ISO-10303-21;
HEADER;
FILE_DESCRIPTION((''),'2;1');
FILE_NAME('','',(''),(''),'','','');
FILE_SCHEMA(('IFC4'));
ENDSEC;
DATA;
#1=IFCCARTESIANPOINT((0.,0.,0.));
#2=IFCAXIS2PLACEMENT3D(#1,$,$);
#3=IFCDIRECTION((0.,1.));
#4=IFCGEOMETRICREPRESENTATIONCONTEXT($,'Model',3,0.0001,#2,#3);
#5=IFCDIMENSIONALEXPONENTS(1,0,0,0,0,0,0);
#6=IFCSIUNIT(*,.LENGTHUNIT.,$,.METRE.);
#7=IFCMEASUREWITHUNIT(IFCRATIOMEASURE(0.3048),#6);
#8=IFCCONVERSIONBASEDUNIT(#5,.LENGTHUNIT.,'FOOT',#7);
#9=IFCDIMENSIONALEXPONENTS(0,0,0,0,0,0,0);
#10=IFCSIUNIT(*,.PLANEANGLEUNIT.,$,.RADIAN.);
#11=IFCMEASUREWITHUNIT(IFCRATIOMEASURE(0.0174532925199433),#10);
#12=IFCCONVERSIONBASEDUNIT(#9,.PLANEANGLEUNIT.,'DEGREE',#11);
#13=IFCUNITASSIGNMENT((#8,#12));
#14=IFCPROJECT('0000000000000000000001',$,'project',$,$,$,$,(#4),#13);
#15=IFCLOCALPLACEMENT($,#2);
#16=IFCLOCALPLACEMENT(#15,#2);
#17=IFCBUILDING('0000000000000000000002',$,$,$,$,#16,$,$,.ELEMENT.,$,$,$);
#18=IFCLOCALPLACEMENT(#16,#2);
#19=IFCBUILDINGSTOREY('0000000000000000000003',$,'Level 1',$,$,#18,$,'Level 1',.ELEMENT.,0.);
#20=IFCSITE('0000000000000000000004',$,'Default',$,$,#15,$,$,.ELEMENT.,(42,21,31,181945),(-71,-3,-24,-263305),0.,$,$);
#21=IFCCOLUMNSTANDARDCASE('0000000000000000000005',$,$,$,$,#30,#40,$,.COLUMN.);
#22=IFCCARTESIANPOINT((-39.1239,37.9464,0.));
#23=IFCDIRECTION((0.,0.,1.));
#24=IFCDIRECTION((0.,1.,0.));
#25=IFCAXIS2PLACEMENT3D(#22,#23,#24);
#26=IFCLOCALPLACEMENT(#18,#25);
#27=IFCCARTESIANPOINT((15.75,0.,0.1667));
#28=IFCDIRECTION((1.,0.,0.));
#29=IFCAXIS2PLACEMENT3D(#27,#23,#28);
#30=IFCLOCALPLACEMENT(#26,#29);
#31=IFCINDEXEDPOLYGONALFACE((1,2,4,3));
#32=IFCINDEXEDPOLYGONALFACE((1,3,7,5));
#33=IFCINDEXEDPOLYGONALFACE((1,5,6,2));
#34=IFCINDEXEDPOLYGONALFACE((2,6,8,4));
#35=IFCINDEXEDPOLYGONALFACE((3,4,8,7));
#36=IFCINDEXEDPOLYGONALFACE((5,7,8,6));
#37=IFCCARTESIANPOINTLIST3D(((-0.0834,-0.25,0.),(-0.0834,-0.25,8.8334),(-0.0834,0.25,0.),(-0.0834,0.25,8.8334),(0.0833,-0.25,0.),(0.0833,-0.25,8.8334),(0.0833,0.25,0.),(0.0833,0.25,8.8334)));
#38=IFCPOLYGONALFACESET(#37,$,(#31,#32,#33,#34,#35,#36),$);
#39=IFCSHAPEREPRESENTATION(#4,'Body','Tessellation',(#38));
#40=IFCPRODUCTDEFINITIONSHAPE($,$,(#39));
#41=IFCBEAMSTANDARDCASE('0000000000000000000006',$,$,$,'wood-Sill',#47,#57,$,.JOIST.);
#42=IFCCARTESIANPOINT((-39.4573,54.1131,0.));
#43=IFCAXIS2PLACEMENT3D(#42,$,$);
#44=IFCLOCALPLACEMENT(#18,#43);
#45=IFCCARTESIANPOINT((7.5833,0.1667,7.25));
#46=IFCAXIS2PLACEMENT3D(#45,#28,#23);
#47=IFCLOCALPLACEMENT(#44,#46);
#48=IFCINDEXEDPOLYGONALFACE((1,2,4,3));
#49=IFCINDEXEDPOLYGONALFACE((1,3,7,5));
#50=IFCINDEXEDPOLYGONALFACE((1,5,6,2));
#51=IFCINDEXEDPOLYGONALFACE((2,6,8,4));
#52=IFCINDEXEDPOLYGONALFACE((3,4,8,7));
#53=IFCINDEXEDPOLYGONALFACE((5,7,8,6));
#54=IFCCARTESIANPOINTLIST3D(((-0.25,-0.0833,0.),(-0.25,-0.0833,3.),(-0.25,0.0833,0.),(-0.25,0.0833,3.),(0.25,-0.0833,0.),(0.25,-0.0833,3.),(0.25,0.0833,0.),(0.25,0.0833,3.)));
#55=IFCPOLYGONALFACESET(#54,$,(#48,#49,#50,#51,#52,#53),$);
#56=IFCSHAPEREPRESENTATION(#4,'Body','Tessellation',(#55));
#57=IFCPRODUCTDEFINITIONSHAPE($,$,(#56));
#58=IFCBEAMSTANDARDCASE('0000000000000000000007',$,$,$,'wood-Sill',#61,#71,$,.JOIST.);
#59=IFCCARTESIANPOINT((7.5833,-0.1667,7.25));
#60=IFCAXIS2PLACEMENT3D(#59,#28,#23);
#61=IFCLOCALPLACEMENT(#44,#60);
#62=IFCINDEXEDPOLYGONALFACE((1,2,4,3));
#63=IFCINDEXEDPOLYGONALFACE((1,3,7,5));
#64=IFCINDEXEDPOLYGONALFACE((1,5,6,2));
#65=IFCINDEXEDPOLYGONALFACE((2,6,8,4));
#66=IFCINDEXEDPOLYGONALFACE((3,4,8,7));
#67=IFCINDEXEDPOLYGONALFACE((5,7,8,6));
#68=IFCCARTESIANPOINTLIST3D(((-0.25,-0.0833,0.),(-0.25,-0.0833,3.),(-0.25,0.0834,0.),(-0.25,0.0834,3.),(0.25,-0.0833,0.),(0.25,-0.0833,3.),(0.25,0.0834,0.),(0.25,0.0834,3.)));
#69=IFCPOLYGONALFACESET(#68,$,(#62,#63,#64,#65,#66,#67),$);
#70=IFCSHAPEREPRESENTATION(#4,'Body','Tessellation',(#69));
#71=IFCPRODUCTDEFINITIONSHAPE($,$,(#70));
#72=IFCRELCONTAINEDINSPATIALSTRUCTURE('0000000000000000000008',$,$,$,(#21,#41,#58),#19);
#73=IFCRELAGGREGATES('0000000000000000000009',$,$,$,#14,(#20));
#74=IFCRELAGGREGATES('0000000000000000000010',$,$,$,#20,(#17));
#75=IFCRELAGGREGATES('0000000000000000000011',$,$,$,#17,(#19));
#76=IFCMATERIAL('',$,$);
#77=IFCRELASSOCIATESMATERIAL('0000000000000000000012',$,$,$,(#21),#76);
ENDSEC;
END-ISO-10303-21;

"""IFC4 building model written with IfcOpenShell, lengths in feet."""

from ifc_helpers import new_model, entity, si_unit, converted_unit, direction, frame, origin, origin_with_axes, place, context, project, spatial, rectangle, extrude, material, element, save


model = new_model("IFC4")

# Units and contexts
model_context = context("Model", 3, precision=0.0001, world=origin(), true_north=direction((0.0, 1.0)))
ifc_project = project(units=[converted_unit("LENGTHUNIT", "FOOT", entity("IfcRatioMeasure", 0.3048), si_unit("LENGTHUNIT", "METRE"), dimensions=[1, 0, 0, 0, 0, 0, 0]), converted_unit("PLANEANGLEUNIT", "DEGREE", entity("IfcRatioMeasure", 0.0174532925199433), si_unit("PLANEANGLEUNIT", "RADIAN"), dimensions=[0, 0, 0, 0, 0, 0, 0])], contexts=[model_context])

# Site, building, storey
site_placement = place(None, origin())
site = spatial("IfcSite", under=ifc_project, at=site_placement, Name="Default", CompositionType="ELEMENT", RefLatitude=(42, 21, 31, 181945), RefLongitude=(-71, -3, -24, -263305), RefElevation=0.0)
building_placement = place(site_placement, origin())
building = spatial("IfcBuilding", under=site, at=building_placement, CompositionType="ELEMENT")
storey_placement = place(building_placement, origin())
storey = spatial("IfcBuildingStorey", under=building, at=storey_placement, Name="Level 1", LongName="Level 1", CompositionType="ELEMENT", Elevation=0.0)

# Column
placement_1 = place(storey_placement, frame((-39.4573, 54.1131, 0.0)))
ifc_material_1 = material(Name="")
placement_2 = place(storey_placement, frame((-39.1239, 37.9464, 0.0), z_axis=(0.0, 0.0, 1.0), x_axis=(0.0, 1.0, 0.0)))
for number, where, z_axis, x_axis in (
    (1, (15.75, 0.0, 0.1667), (0.0, 0.0, 1.0), (1.0, 0.0, 0.0)),
):
    element("IfcColumnStandardCase", number, at=place(placement_2, frame(where, z_axis=z_axis, x_axis=x_axis)), inside=storey, material=ifc_material_1, PredefinedType="COLUMN", context=model_context, shape_type="SweptSolid", body=[
        extrude(rectangle(XDim=0.1667, YDim=0.5), origin(), (0.0, 0.0, 1.0), 8.8334),
    ])

# Beams
for number, where, z_axis, x_axis in (
    (2, (7.5833, 0.1667, 7.25), (1.0, 0.0, 0.0), (0.0, 0.0, 1.0)),
    (3, (7.5833, -0.1667, 7.25), (1.0, 0.0, 0.0), (0.0, 0.0, 1.0)),
):
    element("IfcBeamStandardCase", number, at=place(placement_1, frame(where, z_axis=z_axis, x_axis=x_axis)), inside=storey, ObjectType="wood-Sill", PredefinedType="JOIST", context=model_context, shape_type="SweptSolid", body=[
        extrude(rectangle(XDim=0.5, YDim=0.1667), origin_with_axes(), (0.0, 0.0, 1.0), 3.0),
    ])

save(model, "model.ifc")
